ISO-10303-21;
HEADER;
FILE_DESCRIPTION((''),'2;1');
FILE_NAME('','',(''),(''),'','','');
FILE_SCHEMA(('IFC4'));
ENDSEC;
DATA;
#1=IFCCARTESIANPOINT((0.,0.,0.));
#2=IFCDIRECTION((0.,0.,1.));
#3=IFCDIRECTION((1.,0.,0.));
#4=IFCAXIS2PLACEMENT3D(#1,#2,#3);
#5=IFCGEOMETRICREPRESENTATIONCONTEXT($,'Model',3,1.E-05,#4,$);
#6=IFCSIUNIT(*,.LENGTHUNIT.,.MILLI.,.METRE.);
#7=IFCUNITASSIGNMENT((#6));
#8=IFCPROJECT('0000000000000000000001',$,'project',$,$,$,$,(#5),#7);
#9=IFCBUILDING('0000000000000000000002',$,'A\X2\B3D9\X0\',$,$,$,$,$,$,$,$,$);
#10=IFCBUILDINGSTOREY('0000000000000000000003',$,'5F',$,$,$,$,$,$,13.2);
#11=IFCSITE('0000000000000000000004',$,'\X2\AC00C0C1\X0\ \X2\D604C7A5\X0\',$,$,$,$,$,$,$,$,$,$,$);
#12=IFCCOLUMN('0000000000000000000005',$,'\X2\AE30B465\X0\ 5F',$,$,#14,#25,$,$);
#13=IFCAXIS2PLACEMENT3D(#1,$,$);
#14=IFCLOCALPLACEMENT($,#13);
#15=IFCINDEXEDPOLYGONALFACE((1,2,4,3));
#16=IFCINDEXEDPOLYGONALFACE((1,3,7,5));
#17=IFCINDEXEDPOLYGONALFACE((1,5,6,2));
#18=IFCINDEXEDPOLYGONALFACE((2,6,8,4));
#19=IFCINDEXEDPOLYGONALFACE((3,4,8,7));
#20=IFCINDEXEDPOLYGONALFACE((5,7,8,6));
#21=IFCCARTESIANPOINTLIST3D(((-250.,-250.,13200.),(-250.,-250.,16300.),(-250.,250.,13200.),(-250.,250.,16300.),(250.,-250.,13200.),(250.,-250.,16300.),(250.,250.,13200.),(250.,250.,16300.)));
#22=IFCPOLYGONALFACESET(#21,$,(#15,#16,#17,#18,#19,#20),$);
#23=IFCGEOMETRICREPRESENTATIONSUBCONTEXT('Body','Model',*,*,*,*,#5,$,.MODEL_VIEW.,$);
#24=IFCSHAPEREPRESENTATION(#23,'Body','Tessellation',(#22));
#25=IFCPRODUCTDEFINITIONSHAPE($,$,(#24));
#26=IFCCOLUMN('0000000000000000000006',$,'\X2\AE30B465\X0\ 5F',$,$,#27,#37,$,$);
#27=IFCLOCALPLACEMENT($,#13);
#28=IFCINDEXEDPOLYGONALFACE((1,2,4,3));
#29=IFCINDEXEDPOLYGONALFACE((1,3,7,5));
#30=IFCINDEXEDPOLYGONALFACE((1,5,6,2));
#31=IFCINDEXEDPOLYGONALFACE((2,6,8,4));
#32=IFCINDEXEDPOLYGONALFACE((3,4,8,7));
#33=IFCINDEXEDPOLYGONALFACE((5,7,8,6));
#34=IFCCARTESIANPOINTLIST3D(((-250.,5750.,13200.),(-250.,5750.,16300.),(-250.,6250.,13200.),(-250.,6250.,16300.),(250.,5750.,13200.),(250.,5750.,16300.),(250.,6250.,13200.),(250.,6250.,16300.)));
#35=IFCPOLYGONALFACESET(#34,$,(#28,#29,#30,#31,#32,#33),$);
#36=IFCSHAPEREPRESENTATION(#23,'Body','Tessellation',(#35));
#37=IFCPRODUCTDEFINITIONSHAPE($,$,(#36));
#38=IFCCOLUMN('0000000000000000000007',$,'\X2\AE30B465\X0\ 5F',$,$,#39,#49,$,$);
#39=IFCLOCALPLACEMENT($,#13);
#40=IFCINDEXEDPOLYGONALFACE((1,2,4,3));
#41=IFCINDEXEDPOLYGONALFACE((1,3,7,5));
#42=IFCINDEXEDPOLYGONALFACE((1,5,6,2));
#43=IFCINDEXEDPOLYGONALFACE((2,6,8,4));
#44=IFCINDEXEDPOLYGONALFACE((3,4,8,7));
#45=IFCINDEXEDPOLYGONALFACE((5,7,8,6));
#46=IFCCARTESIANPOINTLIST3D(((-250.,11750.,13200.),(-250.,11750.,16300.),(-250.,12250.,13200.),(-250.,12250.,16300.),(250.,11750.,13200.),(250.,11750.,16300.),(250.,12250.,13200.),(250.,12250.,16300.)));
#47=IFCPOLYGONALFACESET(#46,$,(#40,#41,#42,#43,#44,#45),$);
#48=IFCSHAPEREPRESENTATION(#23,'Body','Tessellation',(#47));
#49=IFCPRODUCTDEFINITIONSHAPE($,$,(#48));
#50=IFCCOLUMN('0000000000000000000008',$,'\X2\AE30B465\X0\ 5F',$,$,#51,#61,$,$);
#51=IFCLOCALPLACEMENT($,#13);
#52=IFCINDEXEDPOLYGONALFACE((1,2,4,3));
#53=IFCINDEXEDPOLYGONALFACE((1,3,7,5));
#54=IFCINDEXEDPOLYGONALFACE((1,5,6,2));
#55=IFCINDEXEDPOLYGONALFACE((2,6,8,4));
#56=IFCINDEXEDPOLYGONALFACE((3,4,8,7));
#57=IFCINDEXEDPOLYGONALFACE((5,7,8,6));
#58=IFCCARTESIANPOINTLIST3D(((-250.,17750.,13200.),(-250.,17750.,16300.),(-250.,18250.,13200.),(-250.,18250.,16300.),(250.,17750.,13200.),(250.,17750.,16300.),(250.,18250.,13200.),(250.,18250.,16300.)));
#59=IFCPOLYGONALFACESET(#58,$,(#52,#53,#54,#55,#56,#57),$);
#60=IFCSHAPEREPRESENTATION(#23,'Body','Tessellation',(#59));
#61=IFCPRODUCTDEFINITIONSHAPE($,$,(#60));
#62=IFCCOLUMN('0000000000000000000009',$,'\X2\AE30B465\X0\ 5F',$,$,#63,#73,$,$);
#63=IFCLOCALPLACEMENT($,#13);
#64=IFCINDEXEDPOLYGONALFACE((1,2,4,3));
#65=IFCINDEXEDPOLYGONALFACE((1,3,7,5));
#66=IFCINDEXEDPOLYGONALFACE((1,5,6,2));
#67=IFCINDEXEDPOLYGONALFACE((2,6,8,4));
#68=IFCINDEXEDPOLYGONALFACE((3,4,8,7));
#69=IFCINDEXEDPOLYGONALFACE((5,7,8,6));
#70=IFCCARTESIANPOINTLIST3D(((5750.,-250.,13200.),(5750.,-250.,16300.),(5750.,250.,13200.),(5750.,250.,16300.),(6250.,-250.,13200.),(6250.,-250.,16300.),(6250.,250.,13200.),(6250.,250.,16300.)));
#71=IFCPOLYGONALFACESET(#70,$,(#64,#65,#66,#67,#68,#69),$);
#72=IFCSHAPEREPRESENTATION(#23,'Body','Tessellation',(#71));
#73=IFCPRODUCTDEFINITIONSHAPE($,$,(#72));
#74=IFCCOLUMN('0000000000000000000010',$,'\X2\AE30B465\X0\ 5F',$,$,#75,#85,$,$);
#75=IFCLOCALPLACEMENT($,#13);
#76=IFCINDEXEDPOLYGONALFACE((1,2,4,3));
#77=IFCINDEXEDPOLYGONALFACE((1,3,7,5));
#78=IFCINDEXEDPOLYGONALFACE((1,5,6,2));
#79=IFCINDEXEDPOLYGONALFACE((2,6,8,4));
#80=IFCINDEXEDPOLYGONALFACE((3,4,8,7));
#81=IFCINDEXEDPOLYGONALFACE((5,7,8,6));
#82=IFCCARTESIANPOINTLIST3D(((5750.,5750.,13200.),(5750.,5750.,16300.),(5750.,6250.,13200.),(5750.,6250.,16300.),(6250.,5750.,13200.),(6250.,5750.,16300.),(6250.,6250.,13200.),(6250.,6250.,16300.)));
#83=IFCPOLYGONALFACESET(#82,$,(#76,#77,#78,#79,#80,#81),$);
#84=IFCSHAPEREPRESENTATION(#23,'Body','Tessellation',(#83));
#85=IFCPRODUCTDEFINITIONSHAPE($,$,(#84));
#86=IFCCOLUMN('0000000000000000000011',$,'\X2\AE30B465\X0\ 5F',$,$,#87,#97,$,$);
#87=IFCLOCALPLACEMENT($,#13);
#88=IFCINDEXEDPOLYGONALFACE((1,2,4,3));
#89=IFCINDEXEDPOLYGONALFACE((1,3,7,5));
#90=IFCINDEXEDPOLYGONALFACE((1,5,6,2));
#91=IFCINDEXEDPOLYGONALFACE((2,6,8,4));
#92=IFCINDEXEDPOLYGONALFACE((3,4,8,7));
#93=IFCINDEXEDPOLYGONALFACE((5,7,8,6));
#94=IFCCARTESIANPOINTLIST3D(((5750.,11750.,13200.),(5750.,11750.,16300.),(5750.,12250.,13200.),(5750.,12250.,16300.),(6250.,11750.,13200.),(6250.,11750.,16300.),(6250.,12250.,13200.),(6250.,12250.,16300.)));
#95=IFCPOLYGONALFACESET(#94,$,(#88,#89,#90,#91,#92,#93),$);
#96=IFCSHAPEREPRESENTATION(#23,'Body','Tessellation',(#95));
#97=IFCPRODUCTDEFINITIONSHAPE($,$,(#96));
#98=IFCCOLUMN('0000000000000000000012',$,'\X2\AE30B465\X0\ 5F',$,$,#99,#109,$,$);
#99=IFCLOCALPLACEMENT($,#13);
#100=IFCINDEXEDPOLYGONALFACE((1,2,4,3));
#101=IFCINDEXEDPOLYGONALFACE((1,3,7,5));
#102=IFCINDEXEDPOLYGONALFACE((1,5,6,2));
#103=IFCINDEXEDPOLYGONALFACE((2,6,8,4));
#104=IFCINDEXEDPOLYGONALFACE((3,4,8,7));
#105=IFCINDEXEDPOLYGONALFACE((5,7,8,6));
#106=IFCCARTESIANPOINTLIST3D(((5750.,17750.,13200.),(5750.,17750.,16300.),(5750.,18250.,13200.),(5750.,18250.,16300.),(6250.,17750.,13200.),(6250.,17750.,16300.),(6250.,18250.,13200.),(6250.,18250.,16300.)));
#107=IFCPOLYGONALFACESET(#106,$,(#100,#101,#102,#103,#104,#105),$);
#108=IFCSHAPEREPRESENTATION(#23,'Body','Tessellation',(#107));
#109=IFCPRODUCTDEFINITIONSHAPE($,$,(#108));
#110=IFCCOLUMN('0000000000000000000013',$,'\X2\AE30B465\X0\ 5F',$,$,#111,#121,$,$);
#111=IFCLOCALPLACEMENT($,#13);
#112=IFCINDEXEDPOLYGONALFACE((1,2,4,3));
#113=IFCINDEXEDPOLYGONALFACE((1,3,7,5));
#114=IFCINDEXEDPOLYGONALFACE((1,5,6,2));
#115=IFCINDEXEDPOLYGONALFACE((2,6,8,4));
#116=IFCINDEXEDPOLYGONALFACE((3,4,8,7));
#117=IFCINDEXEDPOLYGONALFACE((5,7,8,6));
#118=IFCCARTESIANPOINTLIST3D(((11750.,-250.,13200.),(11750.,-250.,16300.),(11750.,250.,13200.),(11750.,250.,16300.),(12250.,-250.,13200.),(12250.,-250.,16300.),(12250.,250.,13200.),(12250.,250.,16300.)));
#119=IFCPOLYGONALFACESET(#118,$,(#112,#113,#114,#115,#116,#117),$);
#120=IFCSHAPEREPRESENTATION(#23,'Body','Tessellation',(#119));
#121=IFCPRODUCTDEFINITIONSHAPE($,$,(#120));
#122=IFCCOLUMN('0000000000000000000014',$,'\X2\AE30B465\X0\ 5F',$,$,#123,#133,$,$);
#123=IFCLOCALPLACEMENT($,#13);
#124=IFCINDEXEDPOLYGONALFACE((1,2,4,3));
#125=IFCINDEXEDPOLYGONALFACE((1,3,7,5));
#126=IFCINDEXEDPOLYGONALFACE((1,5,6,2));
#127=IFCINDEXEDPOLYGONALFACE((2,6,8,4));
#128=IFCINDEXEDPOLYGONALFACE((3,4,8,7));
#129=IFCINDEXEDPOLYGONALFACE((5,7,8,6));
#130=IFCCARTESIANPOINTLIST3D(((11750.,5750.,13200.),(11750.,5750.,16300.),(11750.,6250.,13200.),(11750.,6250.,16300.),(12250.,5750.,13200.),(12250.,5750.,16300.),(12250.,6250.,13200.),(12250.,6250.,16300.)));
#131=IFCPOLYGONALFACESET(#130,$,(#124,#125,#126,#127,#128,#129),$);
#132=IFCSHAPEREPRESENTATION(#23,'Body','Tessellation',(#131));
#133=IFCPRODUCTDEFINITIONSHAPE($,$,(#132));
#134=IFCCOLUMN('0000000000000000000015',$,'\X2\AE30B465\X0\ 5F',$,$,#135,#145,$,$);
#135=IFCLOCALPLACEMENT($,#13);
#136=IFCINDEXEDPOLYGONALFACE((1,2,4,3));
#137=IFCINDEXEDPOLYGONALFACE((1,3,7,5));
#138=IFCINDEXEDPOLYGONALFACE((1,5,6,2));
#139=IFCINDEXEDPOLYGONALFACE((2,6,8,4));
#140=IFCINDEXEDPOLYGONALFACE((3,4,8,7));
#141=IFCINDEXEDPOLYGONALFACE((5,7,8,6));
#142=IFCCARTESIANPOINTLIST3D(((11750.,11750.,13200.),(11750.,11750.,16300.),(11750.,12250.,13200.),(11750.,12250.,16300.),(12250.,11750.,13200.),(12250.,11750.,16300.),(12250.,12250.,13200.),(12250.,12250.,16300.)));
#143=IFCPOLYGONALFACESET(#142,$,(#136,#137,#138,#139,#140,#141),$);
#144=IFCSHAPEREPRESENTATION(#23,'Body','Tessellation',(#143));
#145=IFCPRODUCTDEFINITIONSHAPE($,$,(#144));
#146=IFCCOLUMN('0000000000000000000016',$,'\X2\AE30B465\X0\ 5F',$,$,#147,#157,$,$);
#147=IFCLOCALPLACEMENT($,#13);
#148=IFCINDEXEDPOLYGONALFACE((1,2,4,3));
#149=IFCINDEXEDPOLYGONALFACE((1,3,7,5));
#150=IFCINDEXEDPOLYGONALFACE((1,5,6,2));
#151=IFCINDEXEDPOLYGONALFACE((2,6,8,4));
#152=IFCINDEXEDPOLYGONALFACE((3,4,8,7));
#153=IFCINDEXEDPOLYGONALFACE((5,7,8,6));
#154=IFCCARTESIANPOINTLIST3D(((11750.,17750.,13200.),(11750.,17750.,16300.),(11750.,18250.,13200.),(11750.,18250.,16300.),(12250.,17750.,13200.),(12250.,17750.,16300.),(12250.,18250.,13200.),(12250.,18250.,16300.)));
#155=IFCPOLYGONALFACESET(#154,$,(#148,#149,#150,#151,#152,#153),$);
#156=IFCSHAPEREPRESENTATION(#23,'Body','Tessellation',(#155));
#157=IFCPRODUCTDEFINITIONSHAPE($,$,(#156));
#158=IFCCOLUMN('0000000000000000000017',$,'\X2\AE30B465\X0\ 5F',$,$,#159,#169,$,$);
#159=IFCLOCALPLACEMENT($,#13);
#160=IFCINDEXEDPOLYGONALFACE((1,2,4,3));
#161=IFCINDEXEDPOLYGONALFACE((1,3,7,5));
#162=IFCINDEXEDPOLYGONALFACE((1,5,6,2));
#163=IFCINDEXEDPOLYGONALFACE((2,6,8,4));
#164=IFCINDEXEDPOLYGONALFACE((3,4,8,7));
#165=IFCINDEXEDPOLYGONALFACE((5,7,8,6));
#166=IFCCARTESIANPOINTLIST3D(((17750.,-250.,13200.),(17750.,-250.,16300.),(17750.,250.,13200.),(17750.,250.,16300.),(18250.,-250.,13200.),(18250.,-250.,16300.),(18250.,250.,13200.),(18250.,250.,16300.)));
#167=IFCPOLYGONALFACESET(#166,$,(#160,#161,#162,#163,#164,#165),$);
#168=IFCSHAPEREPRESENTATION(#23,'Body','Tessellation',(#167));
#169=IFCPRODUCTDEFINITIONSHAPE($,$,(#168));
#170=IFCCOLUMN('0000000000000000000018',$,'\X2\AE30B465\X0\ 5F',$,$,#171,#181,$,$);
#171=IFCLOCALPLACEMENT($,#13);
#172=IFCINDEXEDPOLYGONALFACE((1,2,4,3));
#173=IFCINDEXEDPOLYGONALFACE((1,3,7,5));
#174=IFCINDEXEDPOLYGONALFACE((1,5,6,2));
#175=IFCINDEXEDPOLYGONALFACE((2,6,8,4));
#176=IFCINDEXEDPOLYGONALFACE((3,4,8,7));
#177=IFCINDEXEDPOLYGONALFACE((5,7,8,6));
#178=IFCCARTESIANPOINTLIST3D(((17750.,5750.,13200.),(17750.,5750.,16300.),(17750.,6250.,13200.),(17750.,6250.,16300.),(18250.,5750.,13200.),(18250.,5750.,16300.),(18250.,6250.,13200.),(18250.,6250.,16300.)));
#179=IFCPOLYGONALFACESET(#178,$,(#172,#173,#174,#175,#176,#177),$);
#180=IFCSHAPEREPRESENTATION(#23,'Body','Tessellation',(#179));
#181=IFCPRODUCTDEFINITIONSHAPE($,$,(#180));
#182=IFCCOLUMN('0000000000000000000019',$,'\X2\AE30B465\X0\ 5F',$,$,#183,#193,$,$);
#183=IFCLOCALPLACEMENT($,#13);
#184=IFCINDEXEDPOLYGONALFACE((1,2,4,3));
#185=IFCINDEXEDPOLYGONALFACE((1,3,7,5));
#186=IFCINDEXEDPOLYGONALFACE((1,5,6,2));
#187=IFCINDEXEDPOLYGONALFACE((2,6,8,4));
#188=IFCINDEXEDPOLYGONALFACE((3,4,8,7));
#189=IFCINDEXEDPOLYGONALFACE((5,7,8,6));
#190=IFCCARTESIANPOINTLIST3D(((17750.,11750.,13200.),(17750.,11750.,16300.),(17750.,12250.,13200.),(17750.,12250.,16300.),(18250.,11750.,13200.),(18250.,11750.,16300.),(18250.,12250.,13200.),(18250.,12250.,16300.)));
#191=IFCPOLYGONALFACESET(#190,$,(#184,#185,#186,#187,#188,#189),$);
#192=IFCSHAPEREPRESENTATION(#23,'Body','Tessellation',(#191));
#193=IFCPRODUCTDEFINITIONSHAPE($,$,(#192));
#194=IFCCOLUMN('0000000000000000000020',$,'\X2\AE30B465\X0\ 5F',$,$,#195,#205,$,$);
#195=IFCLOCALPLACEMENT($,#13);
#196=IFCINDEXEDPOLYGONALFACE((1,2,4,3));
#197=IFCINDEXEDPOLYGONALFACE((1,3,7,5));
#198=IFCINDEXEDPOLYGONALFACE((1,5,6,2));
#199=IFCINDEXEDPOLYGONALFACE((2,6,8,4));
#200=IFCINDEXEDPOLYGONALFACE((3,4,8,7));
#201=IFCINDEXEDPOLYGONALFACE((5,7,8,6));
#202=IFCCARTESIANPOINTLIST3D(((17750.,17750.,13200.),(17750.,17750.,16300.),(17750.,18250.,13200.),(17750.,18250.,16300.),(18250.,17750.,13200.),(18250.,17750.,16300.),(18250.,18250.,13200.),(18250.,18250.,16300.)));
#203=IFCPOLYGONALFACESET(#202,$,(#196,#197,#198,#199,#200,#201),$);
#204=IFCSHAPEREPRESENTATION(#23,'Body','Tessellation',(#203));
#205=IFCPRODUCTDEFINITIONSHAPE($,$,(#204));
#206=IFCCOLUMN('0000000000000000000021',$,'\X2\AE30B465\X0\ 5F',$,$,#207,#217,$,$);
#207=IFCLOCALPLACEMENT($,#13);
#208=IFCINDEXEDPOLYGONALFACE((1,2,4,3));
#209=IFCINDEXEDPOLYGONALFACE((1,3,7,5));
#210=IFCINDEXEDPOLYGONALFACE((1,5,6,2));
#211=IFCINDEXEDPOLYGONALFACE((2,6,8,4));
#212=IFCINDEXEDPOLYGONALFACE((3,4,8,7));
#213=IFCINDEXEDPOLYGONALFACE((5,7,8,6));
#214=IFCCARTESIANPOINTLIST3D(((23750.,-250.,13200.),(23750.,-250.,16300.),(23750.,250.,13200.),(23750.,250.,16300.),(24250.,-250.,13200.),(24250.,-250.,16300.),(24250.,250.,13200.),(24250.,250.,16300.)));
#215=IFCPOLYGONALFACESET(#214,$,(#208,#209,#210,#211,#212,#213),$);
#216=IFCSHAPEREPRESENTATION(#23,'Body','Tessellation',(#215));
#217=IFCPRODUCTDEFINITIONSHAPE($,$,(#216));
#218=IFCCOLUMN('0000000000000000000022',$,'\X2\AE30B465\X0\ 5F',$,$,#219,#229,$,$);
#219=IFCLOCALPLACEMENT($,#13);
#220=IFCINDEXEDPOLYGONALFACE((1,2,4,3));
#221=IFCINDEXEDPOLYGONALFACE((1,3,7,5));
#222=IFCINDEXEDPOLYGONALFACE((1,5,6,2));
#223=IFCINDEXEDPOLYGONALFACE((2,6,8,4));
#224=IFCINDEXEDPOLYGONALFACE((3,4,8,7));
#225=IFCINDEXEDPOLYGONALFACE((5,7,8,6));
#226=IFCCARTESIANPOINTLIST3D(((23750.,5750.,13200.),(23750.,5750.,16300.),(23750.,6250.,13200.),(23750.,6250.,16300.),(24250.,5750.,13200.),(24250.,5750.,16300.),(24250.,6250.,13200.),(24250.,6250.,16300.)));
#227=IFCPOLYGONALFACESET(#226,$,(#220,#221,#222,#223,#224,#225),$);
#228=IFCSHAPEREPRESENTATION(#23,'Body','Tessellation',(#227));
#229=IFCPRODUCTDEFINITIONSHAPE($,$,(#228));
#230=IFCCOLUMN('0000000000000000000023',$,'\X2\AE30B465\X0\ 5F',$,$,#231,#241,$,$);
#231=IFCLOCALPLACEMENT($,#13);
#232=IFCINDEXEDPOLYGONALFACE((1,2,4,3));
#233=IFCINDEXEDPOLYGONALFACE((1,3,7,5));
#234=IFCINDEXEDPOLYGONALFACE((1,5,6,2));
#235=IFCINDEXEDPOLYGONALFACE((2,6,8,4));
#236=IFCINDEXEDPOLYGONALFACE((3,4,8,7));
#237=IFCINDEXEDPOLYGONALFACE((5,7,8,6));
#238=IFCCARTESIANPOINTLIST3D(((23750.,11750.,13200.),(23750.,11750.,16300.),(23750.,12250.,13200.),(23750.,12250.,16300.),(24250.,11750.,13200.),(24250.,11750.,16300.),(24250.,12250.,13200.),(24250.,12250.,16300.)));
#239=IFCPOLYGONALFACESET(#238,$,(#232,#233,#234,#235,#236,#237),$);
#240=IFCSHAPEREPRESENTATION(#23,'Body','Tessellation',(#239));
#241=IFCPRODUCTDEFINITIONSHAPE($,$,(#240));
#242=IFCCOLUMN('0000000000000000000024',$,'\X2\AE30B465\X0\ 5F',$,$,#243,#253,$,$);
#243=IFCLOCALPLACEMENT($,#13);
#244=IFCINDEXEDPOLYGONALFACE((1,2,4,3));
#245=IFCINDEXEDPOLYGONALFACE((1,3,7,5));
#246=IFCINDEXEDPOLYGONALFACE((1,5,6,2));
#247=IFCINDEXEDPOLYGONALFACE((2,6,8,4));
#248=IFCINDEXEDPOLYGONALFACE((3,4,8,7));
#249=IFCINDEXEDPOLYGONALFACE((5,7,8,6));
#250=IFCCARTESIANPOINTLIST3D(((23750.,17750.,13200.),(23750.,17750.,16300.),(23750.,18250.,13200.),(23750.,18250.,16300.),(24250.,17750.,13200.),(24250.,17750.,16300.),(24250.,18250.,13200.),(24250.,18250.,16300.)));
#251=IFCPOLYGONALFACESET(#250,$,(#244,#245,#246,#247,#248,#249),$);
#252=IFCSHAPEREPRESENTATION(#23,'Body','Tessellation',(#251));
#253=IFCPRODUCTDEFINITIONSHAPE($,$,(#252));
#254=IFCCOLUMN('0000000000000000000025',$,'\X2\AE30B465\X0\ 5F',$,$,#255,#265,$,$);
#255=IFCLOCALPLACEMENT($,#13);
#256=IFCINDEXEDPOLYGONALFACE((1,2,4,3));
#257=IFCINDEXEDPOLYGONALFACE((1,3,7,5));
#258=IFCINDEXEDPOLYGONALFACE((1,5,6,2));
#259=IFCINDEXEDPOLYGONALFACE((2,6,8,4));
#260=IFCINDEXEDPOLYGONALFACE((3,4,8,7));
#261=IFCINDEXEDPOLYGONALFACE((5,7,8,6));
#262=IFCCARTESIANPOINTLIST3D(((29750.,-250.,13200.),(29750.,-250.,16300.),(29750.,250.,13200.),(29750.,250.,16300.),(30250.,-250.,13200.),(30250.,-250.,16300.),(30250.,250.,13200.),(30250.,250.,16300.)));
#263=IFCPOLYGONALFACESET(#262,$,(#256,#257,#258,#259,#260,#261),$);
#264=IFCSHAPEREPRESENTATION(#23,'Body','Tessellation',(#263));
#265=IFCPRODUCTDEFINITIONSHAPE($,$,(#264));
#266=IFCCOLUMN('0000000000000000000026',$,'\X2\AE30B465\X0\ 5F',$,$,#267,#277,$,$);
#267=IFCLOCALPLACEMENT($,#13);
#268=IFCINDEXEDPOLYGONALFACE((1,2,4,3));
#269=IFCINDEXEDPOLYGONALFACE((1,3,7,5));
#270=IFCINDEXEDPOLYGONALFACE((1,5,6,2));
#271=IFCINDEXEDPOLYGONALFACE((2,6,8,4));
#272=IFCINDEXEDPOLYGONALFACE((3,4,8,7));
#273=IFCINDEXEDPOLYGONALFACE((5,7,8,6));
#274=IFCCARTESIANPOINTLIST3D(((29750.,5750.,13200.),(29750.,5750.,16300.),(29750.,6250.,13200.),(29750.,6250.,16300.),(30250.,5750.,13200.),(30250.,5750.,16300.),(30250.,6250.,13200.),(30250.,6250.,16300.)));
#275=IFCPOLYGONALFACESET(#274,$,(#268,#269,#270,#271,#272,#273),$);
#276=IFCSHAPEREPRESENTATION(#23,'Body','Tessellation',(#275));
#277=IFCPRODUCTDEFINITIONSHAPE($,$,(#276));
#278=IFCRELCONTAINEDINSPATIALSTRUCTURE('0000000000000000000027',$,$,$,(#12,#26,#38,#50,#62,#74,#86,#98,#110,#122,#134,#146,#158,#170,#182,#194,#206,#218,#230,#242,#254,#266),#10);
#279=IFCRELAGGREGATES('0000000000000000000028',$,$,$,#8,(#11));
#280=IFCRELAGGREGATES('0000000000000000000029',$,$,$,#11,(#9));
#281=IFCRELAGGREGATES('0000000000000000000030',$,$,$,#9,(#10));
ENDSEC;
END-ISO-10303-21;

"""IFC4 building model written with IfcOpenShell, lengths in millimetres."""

from ifc_helpers import new_model, si_unit, frame, origin_with_axes, place, context, subcontext, project, spatial, indexed_curve, outline, extrude, element, save


model = new_model("IFC4")

# Units and contexts
model_context = context("Model", 3, precision=1e-05, world=origin_with_axes())
body_context = subcontext(model_context, "Body", "Model", "MODEL_VIEW")
ifc_project = project(units=[si_unit("LENGTHUNIT", "METRE", prefix="MILLI")], contexts=[model_context])

# Site, building, storey
site = spatial("IfcSite", under=ifc_project, Name="가상 현장")
building = spatial("IfcBuilding", under=site, Name="A동")
storey = spatial("IfcBuildingStorey", under=building, Name="5F", Elevation=13.2)

# Columns
for number, where, z_axis, x_axis, name in (
    (1, (-250.0, -250.0, 13200.0), (0.0, 0.0, 1.0), (1.0, 0.0, 0.0), "기둥 5F"),
    (2, (-250.0, 5750.0, 13200.0), (0.0, 0.0, 1.0), (1.0, 0.0, 0.0), "기둥 5F"),
    (3, (-250.0, 11750.0, 13200.0), (0.0, 0.0, 1.0), (1.0, 0.0, 0.0), "기둥 5F"),
    (4, (-250.0, 17750.0, 13200.0), (0.0, 0.0, 1.0), (1.0, 0.0, 0.0), "기둥 5F"),
    (5, (5750.0, -250.0, 13200.0), (0.0, 0.0, 1.0), (1.0, 0.0, 0.0), "기둥 5F"),
    (6, (5750.0, 5750.0, 13200.0), (0.0, 0.0, 1.0), (1.0, 0.0, 0.0), "기둥 5F"),
    (7, (5750.0, 11750.0, 13200.0), (0.0, 0.0, 1.0), (1.0, 0.0, 0.0), "기둥 5F"),
    (8, (5750.0, 17750.0, 13200.0), (0.0, 0.0, 1.0), (1.0, 0.0, 0.0), "기둥 5F"),
    (9, (11750.0, -250.0, 13200.0), (0.0, 0.0, 1.0), (1.0, 0.0, 0.0), "기둥 5F"),
    (10, (11750.0, 5750.0, 13200.0), (0.0, 0.0, 1.0), (1.0, 0.0, 0.0), "기둥 5F"),
    (11, (11750.0, 11750.0, 13200.0), (0.0, 0.0, 1.0), (1.0, 0.0, 0.0), "기둥 5F"),
    (12, (11750.0, 17750.0, 13200.0), (0.0, 0.0, 1.0), (1.0, 0.0, 0.0), "기둥 5F"),
    (13, (17750.0, -250.0, 13200.0), (0.0, 0.0, 1.0), (1.0, 0.0, 0.0), "기둥 5F"),
    (14, (17750.0, 5750.0, 13200.0), (0.0, 0.0, 1.0), (1.0, 0.0, 0.0), "기둥 5F"),
    (15, (17750.0, 11750.0, 13200.0), (0.0, 0.0, 1.0), (1.0, 0.0, 0.0), "기둥 5F"),
    (16, (17750.0, 17750.0, 13200.0), (0.0, 0.0, 1.0), (1.0, 0.0, 0.0), "기둥 5F"),
    (17, (23750.0, -250.0, 13200.0), (0.0, 0.0, 1.0), (1.0, 0.0, 0.0), "기둥 5F"),
    (18, (23750.0, 5750.0, 13200.0), (0.0, 0.0, 1.0), (1.0, 0.0, 0.0), "기둥 5F"),
    (19, (23750.0, 11750.0, 13200.0), (0.0, 0.0, 1.0), (1.0, 0.0, 0.0), "기둥 5F"),
    (20, (23750.0, 17750.0, 13200.0), (0.0, 0.0, 1.0), (1.0, 0.0, 0.0), "기둥 5F"),
    (21, (29750.0, -250.0, 13200.0), (0.0, 0.0, 1.0), (1.0, 0.0, 0.0), "기둥 5F"),
    (22, (29750.0, 5750.0, 13200.0), (0.0, 0.0, 1.0), (1.0, 0.0, 0.0), "기둥 5F"),
):
    element("IfcColumn", number, at=place(None, frame(where, z_axis=z_axis, x_axis=x_axis)), inside=storey, Name=name, context=body_context, shape_type="SweptSolid", body=[
        extrude(outline(indexed_curve([(0.0, 0.0), (0.0, 500.0), (500.0, 500.0), (500.0, 0.0), (0.0, 0.0)], self_intersect=False)), origin_with_axes(), (0.0, 0.0, 1.0), 3100.0),
    ])

save(model, "model.ifc")
